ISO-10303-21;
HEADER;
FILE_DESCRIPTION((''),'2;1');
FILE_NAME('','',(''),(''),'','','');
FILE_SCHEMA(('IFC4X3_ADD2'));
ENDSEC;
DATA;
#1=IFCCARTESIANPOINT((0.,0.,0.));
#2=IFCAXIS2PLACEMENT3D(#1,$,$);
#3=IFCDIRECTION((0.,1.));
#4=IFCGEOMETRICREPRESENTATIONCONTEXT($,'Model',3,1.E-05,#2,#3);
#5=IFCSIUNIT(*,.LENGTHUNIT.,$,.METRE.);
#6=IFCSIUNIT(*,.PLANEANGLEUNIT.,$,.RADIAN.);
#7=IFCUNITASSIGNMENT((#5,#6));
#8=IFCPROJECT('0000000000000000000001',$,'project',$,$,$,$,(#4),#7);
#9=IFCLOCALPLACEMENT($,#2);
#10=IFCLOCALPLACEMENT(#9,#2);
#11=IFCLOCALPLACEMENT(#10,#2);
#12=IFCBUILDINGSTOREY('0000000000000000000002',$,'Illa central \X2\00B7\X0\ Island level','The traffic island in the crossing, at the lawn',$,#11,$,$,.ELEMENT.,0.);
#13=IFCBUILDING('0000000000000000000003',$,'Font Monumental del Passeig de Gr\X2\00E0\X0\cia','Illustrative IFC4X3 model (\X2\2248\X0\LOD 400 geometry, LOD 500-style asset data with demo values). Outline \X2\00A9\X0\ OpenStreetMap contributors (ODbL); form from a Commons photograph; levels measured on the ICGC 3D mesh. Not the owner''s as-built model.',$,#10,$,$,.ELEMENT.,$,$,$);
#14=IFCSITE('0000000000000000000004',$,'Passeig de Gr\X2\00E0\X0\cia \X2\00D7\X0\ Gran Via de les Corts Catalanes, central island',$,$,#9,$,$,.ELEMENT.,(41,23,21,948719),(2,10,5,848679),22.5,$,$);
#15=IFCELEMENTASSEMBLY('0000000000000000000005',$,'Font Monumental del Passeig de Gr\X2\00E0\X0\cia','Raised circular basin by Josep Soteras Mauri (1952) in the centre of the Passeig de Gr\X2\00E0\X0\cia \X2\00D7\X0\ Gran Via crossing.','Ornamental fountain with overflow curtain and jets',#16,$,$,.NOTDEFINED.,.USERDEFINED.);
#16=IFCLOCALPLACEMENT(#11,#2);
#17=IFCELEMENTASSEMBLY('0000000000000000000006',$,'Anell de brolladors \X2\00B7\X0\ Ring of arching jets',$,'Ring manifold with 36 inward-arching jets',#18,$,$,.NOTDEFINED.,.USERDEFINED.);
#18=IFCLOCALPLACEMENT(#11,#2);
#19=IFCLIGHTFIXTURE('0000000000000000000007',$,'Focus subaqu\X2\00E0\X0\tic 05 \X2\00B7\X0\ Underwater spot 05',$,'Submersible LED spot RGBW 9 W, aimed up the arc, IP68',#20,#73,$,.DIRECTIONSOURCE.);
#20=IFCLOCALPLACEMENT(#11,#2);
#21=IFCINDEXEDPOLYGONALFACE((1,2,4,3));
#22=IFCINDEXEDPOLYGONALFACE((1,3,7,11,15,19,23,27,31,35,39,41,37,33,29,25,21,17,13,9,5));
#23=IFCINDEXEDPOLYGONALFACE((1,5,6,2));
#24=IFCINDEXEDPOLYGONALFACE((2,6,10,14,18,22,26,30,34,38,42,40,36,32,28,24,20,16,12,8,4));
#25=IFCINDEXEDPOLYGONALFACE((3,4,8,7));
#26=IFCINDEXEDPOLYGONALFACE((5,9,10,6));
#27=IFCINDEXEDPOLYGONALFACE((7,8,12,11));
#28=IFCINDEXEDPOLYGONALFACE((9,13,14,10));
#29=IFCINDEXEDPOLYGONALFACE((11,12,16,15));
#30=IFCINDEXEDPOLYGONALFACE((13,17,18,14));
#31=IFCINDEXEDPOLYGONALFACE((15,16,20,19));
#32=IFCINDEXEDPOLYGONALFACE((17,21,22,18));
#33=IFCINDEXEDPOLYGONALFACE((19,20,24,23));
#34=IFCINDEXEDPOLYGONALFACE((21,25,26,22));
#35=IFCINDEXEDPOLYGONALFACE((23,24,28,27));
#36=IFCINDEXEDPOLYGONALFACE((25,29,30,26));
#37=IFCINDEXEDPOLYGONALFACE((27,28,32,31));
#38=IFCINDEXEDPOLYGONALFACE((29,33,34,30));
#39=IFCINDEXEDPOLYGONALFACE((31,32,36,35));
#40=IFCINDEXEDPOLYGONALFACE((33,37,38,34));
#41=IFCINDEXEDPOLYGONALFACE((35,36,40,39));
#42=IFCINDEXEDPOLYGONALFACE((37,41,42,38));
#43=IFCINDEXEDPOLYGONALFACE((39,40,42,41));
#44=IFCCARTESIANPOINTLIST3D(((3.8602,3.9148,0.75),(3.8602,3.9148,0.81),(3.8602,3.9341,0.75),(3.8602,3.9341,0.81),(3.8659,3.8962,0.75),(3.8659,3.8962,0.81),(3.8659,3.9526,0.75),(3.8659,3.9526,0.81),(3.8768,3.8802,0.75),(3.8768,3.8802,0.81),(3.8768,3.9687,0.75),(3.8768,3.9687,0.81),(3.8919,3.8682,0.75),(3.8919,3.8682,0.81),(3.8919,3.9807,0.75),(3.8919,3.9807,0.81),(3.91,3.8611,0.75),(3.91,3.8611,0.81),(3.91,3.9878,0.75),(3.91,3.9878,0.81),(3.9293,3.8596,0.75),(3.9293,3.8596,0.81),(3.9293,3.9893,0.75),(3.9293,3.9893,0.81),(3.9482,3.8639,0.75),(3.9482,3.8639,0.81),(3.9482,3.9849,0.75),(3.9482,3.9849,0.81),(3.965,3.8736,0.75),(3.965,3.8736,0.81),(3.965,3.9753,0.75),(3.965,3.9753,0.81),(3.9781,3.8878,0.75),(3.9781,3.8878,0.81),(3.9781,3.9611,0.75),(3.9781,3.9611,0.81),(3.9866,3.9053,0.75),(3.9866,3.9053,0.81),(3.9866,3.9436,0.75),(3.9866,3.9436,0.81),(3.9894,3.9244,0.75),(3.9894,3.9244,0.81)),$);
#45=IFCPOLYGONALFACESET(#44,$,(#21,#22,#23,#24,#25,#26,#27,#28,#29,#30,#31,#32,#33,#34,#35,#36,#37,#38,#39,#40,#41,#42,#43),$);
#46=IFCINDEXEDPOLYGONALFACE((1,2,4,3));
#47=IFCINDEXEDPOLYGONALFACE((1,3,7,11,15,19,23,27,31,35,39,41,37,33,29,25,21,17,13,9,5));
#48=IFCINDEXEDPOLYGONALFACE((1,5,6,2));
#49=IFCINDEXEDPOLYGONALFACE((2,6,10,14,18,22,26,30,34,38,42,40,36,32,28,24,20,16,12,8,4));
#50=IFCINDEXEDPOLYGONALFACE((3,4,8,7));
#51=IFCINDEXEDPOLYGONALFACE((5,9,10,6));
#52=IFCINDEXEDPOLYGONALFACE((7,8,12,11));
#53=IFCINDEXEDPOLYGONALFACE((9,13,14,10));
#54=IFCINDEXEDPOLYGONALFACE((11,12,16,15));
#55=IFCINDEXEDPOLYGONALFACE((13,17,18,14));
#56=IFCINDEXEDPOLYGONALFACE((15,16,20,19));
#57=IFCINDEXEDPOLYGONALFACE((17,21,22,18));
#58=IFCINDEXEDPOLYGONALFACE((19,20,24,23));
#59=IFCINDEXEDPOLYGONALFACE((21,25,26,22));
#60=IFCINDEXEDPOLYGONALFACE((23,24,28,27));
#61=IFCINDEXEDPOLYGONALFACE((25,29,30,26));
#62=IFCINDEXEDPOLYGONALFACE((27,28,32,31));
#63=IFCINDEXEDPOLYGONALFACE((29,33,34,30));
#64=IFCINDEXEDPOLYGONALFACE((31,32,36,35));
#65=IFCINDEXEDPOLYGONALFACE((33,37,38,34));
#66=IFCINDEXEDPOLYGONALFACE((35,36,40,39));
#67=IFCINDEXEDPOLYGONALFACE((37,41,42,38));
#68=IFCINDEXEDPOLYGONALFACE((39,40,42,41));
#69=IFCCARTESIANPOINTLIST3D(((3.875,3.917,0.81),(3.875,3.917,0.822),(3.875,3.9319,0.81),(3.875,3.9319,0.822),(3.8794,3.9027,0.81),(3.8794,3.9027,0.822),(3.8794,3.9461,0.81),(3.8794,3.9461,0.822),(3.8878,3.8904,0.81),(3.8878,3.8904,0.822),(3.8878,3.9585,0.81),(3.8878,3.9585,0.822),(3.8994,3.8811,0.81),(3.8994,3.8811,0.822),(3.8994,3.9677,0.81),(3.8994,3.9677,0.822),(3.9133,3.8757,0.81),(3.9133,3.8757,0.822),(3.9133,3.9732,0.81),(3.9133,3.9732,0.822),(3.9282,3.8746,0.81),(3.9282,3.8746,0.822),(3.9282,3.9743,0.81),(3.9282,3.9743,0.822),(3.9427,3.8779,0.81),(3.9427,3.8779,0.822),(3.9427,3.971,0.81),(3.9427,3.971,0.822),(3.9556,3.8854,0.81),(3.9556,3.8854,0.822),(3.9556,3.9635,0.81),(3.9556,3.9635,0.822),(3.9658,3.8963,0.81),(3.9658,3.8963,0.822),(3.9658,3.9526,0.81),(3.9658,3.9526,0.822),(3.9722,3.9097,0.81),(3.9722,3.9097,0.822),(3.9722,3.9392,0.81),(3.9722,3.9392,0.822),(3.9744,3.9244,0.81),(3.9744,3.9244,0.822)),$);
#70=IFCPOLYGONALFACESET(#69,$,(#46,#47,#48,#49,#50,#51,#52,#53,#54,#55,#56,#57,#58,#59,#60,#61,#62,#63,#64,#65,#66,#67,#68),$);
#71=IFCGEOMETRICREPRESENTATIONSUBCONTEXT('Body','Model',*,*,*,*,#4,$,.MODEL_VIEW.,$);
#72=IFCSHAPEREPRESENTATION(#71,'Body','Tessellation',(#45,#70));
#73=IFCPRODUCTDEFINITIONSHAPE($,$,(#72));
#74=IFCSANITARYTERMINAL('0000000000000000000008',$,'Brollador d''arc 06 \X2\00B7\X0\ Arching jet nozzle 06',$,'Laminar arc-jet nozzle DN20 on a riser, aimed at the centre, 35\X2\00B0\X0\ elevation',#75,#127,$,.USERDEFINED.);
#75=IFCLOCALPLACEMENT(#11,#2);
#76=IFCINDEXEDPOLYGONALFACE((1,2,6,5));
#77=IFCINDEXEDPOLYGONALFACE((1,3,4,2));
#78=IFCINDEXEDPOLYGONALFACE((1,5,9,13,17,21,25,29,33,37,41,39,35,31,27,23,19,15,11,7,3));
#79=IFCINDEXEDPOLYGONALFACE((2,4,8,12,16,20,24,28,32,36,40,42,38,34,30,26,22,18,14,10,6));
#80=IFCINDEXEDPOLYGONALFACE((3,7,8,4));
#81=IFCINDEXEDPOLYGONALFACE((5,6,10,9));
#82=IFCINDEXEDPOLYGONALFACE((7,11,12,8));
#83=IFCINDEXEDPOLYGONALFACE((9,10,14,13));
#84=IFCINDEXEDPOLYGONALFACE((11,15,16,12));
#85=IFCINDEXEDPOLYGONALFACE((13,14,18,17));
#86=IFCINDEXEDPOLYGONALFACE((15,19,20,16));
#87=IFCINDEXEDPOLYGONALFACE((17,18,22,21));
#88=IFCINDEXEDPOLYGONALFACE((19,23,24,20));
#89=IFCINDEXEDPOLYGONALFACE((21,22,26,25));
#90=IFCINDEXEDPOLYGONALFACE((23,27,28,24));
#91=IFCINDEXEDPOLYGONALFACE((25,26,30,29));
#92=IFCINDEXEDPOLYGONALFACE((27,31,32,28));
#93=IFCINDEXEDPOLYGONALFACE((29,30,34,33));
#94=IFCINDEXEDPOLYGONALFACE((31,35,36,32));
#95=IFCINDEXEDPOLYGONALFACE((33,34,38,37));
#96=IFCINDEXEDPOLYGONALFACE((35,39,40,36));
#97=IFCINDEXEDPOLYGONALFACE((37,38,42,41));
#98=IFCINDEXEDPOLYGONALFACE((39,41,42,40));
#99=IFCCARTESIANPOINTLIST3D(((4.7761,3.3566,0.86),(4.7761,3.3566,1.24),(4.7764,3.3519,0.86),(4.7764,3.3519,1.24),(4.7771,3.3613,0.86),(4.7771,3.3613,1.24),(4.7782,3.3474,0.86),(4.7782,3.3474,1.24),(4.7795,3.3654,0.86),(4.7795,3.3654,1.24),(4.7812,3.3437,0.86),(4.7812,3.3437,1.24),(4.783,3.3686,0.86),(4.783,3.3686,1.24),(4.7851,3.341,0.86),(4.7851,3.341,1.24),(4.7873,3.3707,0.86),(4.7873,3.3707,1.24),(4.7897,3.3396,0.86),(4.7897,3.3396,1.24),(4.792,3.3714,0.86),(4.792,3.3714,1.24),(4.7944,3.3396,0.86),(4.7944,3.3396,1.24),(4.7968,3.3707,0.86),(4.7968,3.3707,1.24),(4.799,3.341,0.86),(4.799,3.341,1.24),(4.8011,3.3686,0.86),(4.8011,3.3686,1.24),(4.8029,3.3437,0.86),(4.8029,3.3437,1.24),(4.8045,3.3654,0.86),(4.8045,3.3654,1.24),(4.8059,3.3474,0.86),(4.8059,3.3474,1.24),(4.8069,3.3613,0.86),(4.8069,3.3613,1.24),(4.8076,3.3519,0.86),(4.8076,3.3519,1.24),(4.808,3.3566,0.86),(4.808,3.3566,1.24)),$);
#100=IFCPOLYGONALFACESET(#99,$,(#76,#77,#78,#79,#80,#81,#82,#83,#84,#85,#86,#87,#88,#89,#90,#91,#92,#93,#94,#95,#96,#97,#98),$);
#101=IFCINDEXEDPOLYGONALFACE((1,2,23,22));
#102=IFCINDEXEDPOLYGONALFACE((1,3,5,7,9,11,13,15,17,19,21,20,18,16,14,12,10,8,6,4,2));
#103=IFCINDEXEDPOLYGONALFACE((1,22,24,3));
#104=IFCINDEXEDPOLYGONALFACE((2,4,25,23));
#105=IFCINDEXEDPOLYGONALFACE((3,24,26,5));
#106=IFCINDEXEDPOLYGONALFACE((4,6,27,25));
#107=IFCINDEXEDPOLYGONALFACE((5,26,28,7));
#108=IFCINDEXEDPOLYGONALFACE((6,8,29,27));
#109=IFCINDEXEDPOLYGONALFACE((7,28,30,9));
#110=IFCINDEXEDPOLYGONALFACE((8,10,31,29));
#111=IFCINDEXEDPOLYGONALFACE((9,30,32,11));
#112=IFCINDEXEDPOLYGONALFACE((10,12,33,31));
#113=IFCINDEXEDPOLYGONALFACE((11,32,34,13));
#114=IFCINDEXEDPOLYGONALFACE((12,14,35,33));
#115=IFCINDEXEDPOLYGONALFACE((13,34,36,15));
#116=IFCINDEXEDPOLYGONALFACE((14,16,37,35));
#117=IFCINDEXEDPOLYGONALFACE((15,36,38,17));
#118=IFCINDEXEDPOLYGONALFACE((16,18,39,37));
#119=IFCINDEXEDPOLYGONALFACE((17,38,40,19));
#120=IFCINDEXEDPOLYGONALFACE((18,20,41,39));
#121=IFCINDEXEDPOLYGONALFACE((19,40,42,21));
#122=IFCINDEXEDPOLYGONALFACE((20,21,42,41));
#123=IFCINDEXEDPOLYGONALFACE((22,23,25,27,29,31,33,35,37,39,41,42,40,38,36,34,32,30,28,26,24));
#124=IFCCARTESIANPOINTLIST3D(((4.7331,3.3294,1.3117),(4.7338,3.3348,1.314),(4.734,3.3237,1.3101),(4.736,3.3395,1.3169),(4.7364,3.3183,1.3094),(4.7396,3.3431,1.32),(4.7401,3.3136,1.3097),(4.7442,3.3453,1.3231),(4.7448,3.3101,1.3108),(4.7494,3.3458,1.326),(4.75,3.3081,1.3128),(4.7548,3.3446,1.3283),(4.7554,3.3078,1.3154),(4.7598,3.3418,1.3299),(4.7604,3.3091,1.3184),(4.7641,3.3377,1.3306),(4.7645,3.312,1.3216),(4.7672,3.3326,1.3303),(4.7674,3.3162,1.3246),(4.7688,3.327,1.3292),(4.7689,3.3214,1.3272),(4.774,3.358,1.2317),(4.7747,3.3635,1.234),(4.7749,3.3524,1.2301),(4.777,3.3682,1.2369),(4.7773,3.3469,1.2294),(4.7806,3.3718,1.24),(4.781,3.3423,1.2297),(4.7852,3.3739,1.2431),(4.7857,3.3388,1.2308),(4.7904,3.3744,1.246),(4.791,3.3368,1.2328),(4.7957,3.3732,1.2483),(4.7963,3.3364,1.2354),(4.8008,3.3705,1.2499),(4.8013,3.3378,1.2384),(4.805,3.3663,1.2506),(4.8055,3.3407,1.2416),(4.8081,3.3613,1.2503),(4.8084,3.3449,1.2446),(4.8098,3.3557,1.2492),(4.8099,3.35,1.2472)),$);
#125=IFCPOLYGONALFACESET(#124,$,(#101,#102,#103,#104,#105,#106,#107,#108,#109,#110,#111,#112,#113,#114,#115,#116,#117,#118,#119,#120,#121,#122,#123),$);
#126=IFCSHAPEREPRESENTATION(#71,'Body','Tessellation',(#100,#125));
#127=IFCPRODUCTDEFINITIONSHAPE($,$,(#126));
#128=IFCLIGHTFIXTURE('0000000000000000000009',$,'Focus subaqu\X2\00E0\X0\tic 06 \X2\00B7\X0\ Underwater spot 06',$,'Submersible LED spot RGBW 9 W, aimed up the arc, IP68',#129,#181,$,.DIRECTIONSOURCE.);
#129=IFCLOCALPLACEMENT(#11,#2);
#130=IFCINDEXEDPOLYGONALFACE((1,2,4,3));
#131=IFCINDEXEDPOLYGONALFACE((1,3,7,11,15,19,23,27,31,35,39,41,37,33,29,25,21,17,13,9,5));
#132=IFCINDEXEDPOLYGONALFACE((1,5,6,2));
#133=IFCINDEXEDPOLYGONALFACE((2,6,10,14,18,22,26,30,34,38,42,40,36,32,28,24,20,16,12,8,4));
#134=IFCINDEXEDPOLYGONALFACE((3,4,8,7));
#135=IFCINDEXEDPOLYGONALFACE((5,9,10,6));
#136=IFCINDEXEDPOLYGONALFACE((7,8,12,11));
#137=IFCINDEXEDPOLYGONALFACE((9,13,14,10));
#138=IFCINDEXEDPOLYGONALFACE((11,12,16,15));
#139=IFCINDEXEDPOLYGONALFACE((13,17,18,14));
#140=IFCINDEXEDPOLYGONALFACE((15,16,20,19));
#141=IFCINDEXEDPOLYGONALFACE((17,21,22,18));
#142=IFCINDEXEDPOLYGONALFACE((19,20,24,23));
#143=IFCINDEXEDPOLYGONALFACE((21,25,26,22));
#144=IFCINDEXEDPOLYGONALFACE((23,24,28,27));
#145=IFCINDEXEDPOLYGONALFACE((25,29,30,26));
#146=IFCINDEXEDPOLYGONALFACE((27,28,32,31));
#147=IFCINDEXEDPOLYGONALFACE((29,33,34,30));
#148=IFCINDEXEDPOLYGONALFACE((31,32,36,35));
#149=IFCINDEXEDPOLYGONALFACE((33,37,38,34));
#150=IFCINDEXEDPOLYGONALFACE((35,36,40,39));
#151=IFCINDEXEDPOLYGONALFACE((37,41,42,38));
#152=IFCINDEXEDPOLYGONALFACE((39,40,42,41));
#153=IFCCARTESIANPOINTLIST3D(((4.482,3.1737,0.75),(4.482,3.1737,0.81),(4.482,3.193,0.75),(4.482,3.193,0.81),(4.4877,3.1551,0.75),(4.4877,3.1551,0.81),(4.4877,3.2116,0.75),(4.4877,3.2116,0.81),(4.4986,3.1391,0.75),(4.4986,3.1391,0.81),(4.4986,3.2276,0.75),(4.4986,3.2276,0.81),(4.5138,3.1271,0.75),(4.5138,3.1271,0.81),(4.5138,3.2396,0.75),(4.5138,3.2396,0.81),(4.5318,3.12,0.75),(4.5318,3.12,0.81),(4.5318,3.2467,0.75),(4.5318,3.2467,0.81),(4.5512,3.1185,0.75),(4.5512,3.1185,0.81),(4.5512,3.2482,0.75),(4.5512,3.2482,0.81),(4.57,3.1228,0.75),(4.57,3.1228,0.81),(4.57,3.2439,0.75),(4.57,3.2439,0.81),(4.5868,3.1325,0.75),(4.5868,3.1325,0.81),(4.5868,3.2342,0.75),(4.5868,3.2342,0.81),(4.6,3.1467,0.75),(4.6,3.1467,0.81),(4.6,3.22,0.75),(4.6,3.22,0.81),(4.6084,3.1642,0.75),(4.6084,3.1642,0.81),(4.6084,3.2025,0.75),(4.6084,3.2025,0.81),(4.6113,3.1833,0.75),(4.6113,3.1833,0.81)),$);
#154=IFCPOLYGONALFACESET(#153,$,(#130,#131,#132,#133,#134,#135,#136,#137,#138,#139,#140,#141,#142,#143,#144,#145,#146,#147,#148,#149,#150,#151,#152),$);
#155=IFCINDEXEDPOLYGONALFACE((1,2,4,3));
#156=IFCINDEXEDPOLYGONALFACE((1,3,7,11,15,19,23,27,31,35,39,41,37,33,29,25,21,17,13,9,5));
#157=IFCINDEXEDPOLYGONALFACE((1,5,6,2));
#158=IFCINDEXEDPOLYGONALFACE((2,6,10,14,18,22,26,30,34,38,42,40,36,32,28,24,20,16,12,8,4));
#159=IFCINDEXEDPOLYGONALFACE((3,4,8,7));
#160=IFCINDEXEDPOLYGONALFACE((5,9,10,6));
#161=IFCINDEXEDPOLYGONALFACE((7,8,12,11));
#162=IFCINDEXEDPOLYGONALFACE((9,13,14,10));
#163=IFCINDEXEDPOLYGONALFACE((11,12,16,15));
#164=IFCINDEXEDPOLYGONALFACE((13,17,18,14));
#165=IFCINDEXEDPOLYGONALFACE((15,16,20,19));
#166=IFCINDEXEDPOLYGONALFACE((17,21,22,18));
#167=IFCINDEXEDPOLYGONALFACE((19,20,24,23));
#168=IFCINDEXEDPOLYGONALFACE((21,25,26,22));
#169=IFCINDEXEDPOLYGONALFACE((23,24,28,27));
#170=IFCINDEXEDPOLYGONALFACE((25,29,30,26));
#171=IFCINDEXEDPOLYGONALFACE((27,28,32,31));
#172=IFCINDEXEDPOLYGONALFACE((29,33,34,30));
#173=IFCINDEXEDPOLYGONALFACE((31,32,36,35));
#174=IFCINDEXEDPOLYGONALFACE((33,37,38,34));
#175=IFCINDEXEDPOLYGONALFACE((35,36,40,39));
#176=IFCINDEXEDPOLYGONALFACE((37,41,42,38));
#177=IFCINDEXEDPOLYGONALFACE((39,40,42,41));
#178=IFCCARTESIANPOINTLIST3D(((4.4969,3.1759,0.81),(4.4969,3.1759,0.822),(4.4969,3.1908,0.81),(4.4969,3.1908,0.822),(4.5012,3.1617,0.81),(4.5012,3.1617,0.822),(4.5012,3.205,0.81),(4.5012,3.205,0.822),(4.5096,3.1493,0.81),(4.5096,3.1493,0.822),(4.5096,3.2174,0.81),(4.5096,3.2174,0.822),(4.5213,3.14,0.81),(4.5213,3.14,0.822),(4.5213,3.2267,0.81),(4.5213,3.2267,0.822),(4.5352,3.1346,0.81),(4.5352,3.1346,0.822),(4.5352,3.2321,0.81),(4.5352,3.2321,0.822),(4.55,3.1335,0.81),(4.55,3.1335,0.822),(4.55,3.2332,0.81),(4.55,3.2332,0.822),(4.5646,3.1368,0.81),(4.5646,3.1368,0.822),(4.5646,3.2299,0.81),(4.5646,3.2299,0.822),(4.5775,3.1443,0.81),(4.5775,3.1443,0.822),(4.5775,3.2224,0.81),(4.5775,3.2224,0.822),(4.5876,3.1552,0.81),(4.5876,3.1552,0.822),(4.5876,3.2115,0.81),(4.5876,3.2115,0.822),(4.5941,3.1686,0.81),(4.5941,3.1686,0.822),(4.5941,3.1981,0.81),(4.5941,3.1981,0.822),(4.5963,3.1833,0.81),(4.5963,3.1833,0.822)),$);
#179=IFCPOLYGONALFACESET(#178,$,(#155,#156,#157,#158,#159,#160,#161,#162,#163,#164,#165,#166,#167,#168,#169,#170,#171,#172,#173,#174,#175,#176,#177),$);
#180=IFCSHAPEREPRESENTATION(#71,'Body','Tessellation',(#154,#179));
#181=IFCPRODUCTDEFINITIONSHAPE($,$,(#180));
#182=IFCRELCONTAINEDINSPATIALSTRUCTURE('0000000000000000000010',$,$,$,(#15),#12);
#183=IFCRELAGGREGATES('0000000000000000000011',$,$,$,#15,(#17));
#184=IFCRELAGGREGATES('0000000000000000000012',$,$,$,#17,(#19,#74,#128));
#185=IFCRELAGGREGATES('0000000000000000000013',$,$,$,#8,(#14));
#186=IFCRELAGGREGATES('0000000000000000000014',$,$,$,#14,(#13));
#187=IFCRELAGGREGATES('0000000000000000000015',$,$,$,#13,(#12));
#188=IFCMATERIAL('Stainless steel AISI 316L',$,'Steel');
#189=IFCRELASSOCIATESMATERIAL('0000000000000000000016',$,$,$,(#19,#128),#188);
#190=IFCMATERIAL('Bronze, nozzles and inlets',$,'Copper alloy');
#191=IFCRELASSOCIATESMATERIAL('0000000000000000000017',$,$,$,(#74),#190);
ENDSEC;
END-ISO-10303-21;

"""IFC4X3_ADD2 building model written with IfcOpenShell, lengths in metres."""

from ifc_helpers import new_model, si_unit, direction, frame, origin, origin_2d_with_axis, place, context, subcontext, project, spatial, circle, extrude, material, element, aggregate, save


model = new_model("IFC4X3_ADD2")

# Units and contexts
model_context = context("Model", 3, precision=1e-05, world=origin(), true_north=direction((0.0, 1.0)))
body_context = subcontext(model_context, "Body", "Model", "MODEL_VIEW")
ifc_project = project(units=[si_unit("LENGTHUNIT", "METRE"), si_unit("PLANEANGLEUNIT", "RADIAN")], contexts=[model_context])

# Site, building, storey
site_placement = place(None, origin())
site = spatial("IfcSite", under=ifc_project, at=site_placement, Name="Passeig de Gràcia × Gran Via de les Corts Catalanes, central island", CompositionType="ELEMENT", RefLatitude=(41, 23, 21, 948719), RefLongitude=(2, 10, 5, 848679), RefElevation=22.5)
building_placement = place(site_placement, origin())
building = spatial("IfcBuilding", under=site, at=building_placement, Name="Font Monumental del Passeig de Gràcia", Description="Illustrative IFC4X3 model (≈LOD 400 geometry, LOD 500-style asset data with demo values). Outline © OpenStreetMap contributors (ODbL); form from a Commons photograph; levels measured on the ICGC 3D mesh. Not the owner's as-built model.", CompositionType="ELEMENT")
storey_placement = place(building_placement, origin())
storey = spatial("IfcBuildingStorey", under=building, at=storey_placement, Name="Illa central · Island level", Description="The traffic island in the crossing, at the lawn", CompositionType="ELEMENT", Elevation=0.0)

# Element assemblies, light fixtures, sanitary terminal
assembly_1_placement = place(building_placement, origin())
assembly_1 = element("IfcElementAssembly", 1, at=assembly_1_placement, inside=storey, Name="Font Monumental del Passeig de Gràcia", Description="Raised circular basin by Josep Soteras Mauri (1952) in the centre of the Passeig de Gràcia × Gran Via crossing.", ObjectType="Ornamental fountain with overflow curtain and jets", AssemblyPlace="NOTDEFINED", PredefinedType="USERDEFINED")
ifc_material_1 = material(Name="Bronze, nozzles and inlets", Category="Copper alloy")
ifc_material_2 = material(Name="Stainless steel AISI 316L", Category="Steel")
assembly_2_placement = place(building_placement, origin())
assembly_2 = element("IfcElementAssembly", 2, at=assembly_2_placement, Name="Anell de brolladors · Ring of arching jets", ObjectType="Ring manifold with 36 inward-arching jets", AssemblyPlace="NOTDEFINED", PredefinedType="USERDEFINED")
light_fixture_1_placement = place(building_placement, origin())
light_fixture_1 = element("IfcLightFixture", 3, at=light_fixture_1_placement, material=ifc_material_2, Name="Focus subaquàtic 05 · Underwater spot 05", ObjectType="Submersible LED spot RGBW 9 W, aimed up the arc, IP68", PredefinedType="DIRECTIONSOURCE", context=body_context, shape_type="SweptSolid", body=[
    extrude(circle(Radius=0.065, at=origin_2d_with_axis()), frame((3.9244, 3.9244, 0.75)), (0.0, 0.0, 1.0), 0.06),
    extrude(circle(Radius=0.05, at=origin_2d_with_axis()), frame((3.9244, 3.9244, 0.81)), (0.0, 0.0, 1.0), 0.012),
])
sanitary_terminal_1_placement = place(building_placement, origin())
sanitary_terminal_1 = element("IfcSanitaryTerminal", 4, at=sanitary_terminal_1_placement, material=ifc_material_1, Name="Brollador d'arc 06 · Arching jet nozzle 06", ObjectType="Laminar arc-jet nozzle DN20 on a riser, aimed at the centre, 35° elevation", PredefinedType="USERDEFINED", context=body_context, shape_type="SweptSolid", body=[
    extrude(circle(Radius=0.016, at=origin_2d_with_axis()), frame((4.792, 3.3554, 0.86), z_axis=(0.0, 0.0, 1.0), x_axis=(0.0, 1.0, 0.0)), (0.0, 0.0, 1.0), 0.38),
    extrude(circle(Radius=0.02, at=origin_2d_with_axis()), frame((4.792, 3.3554, 1.24), z_axis=(-0.43415, -0.303995, 0.847998), x_axis=(-0.573576, 0.819152, 0.0)), (0.0, 0.0, 1.0), 0.0943),
])
light_fixture_2_placement = place(building_placement, origin())
light_fixture_2 = element("IfcLightFixture", 5, at=light_fixture_2_placement, material=ifc_material_2, Name="Focus subaquàtic 06 · Underwater spot 06", ObjectType="Submersible LED spot RGBW 9 W, aimed up the arc, IP68", PredefinedType="DIRECTIONSOURCE", context=body_context, shape_type="SweptSolid", body=[
    extrude(circle(Radius=0.065, at=origin_2d_with_axis()), frame((4.5463, 3.1833, 0.75)), (0.0, 0.0, 1.0), 0.06),
    extrude(circle(Radius=0.05, at=origin_2d_with_axis()), frame((4.5463, 3.1833, 0.81)), (0.0, 0.0, 1.0), 0.012),
])
aggregate(assembly_1, [assembly_2])
aggregate(assembly_2, [light_fixture_1, sanitary_terminal_1, light_fixture_2])

save(model, "model.ifc")
